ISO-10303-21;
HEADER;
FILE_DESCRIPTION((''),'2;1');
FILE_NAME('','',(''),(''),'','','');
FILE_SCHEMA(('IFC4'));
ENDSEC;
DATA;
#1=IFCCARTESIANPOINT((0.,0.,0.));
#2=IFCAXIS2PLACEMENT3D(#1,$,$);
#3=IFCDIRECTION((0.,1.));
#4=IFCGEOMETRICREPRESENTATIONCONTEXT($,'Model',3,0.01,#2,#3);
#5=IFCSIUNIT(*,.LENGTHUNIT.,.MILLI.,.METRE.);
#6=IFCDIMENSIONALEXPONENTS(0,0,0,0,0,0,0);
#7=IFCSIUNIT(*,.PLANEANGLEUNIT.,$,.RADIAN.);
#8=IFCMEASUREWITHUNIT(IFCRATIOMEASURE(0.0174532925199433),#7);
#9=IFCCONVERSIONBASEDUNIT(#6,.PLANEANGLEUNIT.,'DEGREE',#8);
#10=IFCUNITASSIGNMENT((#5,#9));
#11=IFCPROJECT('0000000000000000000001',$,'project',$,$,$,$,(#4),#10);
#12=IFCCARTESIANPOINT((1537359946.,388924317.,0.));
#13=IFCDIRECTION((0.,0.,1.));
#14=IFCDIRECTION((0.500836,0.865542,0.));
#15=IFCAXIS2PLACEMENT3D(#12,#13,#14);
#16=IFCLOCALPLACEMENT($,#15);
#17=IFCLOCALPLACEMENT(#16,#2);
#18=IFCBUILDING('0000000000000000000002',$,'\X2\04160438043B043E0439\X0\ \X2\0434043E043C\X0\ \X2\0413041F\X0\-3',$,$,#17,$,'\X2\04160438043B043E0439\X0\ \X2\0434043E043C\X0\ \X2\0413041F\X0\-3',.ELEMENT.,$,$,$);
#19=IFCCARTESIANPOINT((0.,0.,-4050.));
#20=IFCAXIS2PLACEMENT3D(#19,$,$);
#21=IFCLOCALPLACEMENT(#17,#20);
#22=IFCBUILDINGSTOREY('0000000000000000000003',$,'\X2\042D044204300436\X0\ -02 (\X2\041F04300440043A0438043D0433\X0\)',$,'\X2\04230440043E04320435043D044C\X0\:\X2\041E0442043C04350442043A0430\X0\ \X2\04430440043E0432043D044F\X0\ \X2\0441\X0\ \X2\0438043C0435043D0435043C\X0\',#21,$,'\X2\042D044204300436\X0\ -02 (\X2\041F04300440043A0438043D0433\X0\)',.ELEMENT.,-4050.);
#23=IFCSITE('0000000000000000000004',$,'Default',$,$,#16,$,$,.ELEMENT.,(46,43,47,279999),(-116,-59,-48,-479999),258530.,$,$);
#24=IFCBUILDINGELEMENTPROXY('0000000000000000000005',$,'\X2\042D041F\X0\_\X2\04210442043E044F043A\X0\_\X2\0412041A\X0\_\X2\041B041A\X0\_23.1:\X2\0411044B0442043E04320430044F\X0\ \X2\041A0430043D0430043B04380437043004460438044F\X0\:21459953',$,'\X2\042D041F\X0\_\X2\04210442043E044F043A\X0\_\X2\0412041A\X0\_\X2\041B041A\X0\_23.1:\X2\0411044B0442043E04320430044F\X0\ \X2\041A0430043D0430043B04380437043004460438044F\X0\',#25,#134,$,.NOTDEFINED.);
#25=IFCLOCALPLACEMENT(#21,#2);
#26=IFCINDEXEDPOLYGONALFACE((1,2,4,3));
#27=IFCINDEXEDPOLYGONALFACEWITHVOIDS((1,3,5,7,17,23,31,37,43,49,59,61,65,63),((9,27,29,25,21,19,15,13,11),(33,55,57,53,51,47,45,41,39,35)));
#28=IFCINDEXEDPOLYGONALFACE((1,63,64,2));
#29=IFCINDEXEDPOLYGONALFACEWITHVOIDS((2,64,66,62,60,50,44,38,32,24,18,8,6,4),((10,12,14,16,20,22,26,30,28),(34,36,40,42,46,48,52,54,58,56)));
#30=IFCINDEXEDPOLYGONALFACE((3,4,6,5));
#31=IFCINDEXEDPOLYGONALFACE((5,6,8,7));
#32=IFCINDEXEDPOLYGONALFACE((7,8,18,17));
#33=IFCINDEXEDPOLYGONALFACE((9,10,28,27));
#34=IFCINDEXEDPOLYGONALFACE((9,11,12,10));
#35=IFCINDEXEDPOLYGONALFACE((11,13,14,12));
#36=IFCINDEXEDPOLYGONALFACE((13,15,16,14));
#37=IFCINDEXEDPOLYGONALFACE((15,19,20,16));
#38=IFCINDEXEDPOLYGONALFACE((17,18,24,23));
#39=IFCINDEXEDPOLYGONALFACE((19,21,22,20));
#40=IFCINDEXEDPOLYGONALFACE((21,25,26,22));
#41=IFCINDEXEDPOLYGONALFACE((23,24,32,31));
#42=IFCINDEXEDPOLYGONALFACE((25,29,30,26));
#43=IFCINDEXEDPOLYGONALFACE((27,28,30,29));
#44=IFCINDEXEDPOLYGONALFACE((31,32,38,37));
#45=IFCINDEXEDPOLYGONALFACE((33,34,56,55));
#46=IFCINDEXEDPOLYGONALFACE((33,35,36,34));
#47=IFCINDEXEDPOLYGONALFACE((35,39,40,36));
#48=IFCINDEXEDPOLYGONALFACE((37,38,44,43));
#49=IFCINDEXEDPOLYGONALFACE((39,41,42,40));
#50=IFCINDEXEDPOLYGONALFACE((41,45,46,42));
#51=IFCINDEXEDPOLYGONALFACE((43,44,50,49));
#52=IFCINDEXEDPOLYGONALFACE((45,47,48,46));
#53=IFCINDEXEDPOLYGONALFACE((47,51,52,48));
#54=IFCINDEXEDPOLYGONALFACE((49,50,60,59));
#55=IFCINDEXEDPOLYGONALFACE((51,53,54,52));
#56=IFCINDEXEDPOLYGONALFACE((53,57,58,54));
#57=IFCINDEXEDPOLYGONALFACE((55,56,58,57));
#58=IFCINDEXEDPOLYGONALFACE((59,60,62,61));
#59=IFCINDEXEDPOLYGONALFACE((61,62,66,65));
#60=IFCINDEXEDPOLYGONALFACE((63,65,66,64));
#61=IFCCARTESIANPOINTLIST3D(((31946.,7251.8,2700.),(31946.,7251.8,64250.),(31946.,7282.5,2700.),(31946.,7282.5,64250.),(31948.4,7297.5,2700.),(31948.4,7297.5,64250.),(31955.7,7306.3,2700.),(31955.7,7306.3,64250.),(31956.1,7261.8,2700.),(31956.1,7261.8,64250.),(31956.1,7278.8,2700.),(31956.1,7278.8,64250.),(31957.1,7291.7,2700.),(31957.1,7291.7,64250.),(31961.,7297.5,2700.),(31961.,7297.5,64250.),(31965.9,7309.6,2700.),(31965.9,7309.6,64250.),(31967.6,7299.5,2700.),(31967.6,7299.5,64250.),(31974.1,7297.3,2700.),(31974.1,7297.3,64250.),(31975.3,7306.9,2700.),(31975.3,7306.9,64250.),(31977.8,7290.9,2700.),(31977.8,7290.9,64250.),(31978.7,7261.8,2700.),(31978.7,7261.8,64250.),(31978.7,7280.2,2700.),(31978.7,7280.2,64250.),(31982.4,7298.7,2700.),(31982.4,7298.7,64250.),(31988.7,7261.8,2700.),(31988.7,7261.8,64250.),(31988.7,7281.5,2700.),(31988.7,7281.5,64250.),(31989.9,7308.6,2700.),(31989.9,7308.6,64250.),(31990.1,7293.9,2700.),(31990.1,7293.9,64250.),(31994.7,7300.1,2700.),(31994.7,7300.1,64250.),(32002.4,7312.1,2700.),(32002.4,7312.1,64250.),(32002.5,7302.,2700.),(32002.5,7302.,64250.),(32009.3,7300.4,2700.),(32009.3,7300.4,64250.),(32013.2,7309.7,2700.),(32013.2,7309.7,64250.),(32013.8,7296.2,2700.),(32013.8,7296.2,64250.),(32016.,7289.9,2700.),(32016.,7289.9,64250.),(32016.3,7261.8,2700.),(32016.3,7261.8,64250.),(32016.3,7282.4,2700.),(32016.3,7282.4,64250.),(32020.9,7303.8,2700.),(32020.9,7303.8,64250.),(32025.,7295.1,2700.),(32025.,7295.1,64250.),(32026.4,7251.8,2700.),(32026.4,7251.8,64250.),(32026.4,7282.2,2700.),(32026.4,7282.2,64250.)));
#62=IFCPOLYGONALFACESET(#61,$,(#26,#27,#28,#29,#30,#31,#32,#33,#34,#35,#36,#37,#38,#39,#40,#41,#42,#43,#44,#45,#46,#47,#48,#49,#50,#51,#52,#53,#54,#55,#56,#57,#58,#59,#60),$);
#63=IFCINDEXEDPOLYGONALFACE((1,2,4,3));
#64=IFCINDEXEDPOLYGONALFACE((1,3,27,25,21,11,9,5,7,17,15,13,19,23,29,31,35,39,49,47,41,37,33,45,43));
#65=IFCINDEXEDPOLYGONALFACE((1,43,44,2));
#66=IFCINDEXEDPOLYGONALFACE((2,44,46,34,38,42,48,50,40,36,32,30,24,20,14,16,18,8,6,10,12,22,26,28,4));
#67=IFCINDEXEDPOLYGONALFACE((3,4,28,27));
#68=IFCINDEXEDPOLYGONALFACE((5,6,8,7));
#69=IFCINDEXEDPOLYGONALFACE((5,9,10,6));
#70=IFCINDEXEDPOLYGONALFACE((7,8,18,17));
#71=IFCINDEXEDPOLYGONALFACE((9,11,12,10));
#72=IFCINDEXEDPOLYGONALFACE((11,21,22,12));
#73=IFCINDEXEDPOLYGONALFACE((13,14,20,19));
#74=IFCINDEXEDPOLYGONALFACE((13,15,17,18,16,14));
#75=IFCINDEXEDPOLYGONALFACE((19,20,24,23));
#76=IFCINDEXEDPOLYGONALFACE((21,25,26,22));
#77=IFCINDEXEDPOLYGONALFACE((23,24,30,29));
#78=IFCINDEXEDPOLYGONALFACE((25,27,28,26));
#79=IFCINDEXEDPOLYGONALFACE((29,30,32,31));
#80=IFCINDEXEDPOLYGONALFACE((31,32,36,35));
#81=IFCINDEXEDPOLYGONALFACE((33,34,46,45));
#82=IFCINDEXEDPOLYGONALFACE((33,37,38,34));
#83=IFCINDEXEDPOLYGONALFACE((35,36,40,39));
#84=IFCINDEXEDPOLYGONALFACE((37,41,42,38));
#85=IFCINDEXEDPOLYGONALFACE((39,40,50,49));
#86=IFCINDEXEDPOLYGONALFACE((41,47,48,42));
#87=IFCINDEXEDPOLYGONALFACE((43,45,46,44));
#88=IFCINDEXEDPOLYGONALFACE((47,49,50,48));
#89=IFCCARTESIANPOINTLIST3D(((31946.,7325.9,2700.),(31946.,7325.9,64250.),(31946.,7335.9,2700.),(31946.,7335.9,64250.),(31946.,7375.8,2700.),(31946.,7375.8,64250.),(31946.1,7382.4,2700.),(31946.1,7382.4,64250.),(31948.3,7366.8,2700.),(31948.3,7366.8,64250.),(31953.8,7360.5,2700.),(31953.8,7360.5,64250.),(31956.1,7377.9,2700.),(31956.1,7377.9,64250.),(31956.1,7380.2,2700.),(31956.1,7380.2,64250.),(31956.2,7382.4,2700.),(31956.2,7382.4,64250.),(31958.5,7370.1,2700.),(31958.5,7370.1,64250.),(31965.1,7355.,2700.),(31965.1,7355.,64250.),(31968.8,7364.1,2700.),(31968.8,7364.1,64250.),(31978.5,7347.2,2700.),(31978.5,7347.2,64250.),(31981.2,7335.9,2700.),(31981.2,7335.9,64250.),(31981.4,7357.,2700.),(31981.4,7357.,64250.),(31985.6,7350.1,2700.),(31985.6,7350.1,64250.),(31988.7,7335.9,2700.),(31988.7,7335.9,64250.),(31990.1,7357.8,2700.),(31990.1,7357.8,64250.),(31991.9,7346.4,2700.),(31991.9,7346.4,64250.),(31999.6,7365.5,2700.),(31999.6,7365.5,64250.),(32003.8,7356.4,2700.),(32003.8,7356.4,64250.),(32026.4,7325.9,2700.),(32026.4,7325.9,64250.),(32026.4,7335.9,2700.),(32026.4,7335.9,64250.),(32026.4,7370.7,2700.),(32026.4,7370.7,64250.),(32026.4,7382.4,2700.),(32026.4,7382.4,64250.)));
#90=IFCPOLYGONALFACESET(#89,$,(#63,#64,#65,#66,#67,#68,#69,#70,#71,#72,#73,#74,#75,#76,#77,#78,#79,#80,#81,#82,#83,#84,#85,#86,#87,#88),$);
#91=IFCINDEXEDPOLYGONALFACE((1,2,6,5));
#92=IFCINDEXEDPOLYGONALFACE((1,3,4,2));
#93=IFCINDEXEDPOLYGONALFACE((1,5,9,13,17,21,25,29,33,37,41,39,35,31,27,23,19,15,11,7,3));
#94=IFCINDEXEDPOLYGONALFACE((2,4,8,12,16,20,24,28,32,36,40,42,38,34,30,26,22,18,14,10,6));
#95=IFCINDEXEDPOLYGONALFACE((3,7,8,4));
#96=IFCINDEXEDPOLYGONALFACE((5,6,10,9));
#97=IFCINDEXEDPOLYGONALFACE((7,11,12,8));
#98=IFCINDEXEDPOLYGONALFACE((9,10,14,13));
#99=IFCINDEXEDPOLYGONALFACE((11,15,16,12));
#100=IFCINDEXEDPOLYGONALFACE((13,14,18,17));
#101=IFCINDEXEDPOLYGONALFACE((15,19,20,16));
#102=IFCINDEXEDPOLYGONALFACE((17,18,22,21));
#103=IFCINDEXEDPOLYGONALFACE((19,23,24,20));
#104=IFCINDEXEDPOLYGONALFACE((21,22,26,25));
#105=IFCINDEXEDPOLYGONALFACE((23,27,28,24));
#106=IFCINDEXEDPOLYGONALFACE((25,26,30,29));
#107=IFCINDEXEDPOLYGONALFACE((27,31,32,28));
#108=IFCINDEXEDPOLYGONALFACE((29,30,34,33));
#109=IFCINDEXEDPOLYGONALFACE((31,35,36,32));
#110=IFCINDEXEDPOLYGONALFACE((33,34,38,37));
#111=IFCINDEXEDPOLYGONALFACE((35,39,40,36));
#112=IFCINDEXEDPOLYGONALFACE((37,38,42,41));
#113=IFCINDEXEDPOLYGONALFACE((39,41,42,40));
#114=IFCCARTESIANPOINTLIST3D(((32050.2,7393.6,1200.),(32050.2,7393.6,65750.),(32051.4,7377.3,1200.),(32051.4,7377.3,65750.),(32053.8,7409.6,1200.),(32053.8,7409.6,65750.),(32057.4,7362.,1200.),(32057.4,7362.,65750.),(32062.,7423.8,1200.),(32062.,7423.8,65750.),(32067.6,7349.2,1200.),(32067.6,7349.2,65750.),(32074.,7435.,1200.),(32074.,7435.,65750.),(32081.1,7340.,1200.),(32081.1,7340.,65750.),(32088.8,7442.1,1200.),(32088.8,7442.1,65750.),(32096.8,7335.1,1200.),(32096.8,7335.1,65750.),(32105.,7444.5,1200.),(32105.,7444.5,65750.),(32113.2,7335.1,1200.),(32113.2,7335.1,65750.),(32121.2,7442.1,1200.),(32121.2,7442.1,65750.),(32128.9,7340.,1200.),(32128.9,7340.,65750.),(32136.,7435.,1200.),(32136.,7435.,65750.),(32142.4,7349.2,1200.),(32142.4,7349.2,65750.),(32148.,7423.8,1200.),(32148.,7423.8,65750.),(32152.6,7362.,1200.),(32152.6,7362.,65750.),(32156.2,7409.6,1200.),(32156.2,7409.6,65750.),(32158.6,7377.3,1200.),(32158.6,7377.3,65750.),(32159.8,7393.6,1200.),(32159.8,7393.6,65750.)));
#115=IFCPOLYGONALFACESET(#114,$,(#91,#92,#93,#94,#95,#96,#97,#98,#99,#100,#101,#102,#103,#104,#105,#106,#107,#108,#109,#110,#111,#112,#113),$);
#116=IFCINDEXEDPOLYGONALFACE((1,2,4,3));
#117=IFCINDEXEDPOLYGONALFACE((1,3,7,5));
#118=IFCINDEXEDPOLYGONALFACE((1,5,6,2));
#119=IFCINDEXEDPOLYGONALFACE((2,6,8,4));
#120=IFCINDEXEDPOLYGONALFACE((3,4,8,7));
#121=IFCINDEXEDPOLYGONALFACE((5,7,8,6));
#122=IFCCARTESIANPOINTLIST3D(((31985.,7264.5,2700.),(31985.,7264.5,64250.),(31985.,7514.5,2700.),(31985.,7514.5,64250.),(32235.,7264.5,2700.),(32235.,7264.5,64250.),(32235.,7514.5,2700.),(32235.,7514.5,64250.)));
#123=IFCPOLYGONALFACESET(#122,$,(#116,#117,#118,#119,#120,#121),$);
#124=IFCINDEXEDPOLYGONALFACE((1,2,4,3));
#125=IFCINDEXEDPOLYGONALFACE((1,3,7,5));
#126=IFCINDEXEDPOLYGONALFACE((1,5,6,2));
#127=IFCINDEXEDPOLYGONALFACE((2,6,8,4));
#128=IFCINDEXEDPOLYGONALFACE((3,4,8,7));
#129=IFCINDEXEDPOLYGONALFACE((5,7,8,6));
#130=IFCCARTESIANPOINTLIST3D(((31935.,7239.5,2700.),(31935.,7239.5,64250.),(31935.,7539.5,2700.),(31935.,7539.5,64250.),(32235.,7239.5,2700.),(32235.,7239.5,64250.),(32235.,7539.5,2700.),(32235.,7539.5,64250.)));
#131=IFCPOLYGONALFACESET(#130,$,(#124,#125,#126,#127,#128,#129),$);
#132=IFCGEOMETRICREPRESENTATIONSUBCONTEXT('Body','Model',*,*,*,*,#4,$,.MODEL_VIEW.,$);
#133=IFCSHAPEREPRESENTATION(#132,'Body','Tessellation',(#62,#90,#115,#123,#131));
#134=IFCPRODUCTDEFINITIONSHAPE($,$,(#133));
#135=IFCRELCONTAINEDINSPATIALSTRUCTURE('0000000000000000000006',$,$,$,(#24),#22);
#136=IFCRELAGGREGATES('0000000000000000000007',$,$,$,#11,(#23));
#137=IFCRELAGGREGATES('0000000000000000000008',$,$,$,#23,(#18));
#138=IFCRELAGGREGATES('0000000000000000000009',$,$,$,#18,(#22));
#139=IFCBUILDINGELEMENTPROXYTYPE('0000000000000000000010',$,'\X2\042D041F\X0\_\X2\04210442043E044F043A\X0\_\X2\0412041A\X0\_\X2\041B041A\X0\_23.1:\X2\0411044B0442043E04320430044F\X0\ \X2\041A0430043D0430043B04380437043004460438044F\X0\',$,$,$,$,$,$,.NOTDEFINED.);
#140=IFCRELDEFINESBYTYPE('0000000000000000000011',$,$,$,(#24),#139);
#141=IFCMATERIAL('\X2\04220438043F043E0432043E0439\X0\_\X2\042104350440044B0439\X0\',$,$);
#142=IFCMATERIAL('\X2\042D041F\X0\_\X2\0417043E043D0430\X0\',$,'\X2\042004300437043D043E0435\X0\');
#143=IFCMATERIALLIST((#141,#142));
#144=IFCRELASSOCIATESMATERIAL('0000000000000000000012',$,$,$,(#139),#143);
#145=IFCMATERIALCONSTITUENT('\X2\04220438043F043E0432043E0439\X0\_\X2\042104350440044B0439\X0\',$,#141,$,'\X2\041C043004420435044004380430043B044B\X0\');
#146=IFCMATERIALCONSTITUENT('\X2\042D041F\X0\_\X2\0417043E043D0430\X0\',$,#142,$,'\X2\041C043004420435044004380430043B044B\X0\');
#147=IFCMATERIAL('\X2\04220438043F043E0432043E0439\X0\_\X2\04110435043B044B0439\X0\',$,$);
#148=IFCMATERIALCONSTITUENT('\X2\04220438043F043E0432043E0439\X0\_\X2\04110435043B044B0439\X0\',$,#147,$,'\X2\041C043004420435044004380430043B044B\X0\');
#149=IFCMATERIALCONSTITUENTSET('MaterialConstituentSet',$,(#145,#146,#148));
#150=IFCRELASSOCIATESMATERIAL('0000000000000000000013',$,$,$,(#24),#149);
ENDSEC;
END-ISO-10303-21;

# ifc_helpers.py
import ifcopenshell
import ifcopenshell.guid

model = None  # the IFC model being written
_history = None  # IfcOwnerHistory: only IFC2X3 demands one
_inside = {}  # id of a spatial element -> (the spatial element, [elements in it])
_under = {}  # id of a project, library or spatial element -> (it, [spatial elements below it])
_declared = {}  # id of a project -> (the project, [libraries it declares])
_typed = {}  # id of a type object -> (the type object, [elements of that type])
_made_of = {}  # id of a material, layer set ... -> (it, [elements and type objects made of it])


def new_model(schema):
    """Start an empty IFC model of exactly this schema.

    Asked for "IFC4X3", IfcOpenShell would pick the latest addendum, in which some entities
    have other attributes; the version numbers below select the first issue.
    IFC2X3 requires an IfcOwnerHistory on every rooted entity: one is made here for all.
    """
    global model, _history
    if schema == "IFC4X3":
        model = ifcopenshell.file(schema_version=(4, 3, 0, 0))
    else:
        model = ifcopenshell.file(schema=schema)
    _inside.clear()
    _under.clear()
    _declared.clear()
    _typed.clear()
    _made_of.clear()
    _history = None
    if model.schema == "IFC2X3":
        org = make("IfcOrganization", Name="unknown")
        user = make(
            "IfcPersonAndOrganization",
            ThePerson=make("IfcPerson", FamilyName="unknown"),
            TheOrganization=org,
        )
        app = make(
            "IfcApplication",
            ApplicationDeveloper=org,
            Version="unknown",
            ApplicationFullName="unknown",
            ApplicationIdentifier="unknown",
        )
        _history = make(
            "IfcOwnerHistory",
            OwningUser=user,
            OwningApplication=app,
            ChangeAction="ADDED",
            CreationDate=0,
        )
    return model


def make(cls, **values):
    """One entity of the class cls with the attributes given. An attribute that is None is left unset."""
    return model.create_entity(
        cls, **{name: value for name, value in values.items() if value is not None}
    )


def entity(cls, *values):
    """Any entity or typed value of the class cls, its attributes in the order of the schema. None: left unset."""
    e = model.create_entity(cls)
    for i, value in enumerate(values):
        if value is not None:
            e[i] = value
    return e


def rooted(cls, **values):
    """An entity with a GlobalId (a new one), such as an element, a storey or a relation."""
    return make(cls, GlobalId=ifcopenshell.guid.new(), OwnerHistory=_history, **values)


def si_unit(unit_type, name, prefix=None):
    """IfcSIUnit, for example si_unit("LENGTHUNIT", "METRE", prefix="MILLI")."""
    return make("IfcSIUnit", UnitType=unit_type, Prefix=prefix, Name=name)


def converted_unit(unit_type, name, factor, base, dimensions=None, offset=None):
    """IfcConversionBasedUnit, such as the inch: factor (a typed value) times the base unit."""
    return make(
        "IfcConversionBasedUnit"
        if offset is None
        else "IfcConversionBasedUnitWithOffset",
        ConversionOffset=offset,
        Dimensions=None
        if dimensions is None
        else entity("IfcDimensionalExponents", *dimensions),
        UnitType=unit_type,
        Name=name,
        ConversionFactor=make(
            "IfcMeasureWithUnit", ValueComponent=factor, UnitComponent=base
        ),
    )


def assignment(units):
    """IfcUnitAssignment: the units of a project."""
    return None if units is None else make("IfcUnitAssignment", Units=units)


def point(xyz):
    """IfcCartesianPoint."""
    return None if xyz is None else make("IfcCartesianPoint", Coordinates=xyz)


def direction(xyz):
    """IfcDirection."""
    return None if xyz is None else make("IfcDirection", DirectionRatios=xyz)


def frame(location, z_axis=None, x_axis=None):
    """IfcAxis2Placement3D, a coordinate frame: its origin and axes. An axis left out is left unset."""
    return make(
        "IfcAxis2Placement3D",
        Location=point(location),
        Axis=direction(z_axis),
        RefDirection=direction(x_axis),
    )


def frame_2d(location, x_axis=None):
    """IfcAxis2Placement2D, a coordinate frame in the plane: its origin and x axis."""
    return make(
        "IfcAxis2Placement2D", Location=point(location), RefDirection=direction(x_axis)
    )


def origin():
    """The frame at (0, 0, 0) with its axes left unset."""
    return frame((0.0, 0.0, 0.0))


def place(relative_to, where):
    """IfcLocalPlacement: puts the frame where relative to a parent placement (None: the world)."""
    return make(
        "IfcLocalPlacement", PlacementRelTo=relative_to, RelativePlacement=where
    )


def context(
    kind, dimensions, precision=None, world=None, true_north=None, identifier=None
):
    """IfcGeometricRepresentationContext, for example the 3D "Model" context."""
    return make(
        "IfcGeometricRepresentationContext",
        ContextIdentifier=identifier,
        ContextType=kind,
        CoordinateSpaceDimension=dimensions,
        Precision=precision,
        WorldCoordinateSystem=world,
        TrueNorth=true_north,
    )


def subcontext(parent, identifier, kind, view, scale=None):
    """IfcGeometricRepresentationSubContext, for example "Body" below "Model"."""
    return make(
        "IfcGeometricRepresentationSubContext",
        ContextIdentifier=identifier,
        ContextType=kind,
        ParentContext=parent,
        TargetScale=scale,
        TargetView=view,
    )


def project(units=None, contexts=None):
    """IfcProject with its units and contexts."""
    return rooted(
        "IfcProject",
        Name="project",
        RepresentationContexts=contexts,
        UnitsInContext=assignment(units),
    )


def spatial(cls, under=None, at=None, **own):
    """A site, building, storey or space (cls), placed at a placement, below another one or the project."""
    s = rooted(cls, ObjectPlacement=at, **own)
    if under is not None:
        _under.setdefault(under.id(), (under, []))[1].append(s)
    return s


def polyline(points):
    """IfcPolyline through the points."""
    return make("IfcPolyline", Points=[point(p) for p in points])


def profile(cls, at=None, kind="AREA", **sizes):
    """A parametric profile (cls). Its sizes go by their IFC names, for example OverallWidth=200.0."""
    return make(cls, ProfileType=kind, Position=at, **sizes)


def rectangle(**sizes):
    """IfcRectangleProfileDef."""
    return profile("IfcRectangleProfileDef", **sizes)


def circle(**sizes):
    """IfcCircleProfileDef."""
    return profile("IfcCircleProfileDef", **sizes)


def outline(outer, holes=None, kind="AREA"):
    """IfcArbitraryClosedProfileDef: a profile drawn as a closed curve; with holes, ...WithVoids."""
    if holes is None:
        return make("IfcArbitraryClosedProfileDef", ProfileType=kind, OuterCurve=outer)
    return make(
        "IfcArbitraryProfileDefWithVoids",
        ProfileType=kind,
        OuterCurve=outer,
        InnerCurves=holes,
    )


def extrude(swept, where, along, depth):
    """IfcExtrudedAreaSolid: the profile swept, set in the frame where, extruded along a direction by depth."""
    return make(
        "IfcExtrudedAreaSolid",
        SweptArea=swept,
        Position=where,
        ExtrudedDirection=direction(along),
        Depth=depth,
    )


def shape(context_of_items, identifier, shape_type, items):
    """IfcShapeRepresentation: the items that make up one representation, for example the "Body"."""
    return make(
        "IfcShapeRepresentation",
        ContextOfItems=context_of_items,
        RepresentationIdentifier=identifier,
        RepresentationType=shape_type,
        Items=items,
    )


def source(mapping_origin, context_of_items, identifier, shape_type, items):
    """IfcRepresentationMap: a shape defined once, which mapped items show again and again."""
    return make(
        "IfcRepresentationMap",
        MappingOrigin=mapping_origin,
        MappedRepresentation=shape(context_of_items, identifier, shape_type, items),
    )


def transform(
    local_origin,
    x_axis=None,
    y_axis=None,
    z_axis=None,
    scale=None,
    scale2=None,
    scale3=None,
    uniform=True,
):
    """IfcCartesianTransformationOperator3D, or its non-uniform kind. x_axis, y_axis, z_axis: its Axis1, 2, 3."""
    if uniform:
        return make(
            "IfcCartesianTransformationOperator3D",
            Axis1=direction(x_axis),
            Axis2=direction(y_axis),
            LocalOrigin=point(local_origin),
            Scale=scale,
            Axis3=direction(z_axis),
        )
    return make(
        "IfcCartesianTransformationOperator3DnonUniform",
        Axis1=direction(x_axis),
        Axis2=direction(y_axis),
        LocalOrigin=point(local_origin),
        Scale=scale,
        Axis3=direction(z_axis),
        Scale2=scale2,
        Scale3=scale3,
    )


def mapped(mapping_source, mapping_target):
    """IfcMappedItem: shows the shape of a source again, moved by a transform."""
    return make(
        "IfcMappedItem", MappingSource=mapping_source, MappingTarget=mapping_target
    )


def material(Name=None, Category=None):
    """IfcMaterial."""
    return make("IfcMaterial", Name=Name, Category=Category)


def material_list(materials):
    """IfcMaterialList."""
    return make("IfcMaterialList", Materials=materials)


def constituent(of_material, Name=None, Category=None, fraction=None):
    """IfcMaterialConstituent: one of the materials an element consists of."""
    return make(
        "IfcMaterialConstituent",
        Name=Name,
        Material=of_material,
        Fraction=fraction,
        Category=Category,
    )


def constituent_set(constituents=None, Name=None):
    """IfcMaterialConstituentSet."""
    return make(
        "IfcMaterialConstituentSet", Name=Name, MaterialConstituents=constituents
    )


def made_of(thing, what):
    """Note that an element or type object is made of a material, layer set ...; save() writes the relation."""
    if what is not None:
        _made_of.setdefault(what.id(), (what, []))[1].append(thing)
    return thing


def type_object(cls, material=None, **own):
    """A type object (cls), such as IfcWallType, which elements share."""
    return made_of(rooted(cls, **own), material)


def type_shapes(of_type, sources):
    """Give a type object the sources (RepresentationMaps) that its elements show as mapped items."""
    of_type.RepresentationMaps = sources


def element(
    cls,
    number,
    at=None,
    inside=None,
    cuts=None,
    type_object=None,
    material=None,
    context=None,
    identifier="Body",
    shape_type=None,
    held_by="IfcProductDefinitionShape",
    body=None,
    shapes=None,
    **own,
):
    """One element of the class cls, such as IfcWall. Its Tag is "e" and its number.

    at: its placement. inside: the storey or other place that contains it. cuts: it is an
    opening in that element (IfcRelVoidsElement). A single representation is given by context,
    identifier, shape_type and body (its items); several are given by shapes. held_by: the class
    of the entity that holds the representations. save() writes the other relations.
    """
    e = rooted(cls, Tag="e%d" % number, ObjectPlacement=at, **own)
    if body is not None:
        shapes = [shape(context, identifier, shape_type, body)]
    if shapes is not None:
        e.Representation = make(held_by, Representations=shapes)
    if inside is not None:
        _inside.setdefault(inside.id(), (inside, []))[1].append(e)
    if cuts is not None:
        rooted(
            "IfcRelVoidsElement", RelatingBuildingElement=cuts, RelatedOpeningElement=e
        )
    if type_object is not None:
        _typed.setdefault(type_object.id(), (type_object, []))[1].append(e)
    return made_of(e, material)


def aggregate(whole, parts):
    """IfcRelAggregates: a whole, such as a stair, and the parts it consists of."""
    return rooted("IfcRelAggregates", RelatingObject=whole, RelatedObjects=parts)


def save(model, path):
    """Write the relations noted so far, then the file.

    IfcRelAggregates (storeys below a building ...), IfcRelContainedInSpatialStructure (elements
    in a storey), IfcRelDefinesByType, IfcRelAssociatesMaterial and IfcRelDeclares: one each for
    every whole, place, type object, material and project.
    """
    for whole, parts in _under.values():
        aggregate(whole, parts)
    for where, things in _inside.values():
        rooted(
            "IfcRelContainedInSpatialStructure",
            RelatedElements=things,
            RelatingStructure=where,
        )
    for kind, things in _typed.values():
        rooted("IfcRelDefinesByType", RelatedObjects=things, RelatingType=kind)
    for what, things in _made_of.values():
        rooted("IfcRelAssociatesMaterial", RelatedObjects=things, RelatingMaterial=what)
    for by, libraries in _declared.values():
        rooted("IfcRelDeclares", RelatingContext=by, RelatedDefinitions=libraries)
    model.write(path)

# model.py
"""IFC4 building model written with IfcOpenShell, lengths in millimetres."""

from ifc_helpers import new_model, entity, si_unit, converted_unit, direction, frame, frame_2d, origin, place, context, subcontext, project, spatial, polyline, rectangle, circle, outline, extrude, source, transform, mapped, material, material_list, constituent, constituent_set, type_object, type_shapes, element, save


model = new_model("IFC4")

# Units and contexts
model_context = context("Model", 3, precision=0.01, world=origin(), true_north=direction((0.0, 1.0)))
body_context = subcontext(model_context, "Body", "Model", "MODEL_VIEW")
ifc_project = project(units=[si_unit("LENGTHUNIT", "METRE", prefix="MILLI"), converted_unit("PLANEANGLEUNIT", "DEGREE", entity("IfcRatioMeasure", 0.0174532925199433), si_unit("PLANEANGLEUNIT", "RADIAN"), dimensions=[0, 0, 0, 0, 0, 0, 0])], contexts=[model_context])

# Site, building, storey
site_placement = place(None, frame((1537359946.0, 388924317.0, 0.0), z_axis=(0.0, 0.0, 1.0), x_axis=(0.500836, 0.865542, 0.0)))
site = spatial("IfcSite", under=ifc_project, at=site_placement, Name="Default", CompositionType="ELEMENT", RefLatitude=(46, 43, 47, 279999), RefLongitude=(-116, -59, -48, -479999), RefElevation=258530.0)
building_placement = place(site_placement, origin())
building = spatial("IfcBuilding", under=site, at=building_placement, Name="Жилой дом ГП-3", LongName="Жилой дом ГП-3", CompositionType="ELEMENT")
storey_placement = place(building_placement, frame((0.0, 0.0, -4050.0)))
storey = spatial("IfcBuildingStorey", under=building, at=storey_placement, Name="Этаж -02 (Паркинг)", ObjectType="Уровень:Отметка уровня с именем", LongName="Этаж -02 (Паркинг)", CompositionType="ELEMENT", Elevation=-4050.0)

# Building element proxy
ifc_material_1 = material(Name="ЭП_Зона", Category="Разное")
ifc_material_2 = material(Name="Типовой_Белый")
ifc_material_3 = material(Name="Типовой_Серый")
ifc_constituent_1 = constituent(ifc_material_3, Name="Типовой_Серый", Category="Материалы")
ifc_constituent_2 = constituent(ifc_material_1, Name="ЭП_Зона", Category="Материалы")
ifc_constituent_3 = constituent(ifc_material_2, Name="Типовой_Белый", Category="Материалы")
ifc_constituent_set_1 = constituent_set(constituents=[ifc_constituent_1, ifc_constituent_2, ifc_constituent_3], Name="MaterialConstituentSet")
ifc_material_list_1 = material_list([ifc_material_3, ifc_material_1])
building_element_proxy_type_1 = type_object("IfcBuildingElementProxyType", Name="ЭП_Стояк_ВК_ЛК_23.1:Бытовая Канализация", PredefinedType="NOTDEFINED", material=ifc_material_list_1)
shared_shape_1 = source(origin(), body_context, "Body", "SweptSolid", [
    extrude(outline(polyline([(-42.2, -39.0), (-11.8, -39.0), (1.1, -37.6), (9.8, -33.5), (15.7, -25.8), (18.0, -15.0), (14.6, -2.5), (4.7, 5.0), (12.8, 12.1), (15.5, 21.5), (12.3, 31.8), (3.4, 39.0), (-11.6, 41.4), (-42.2, 41.4), (-42.2, -39.0)]), holes=[polyline([(-32.2, 8.8), (-32.2, 31.4), (-15.2, 31.4), (-2.3, 30.3), (3.5, 26.4), (5.5, 19.9), (3.3, 13.3), (-3.1, 9.6), (-13.9, 8.8), (-32.2, 8.8)]), polyline([(-32.2, -28.9), (-32.2, -1.3), (-12.6, -1.3), (-0.2, -2.6), (6.1, -7.3), (8.0, -15.1), (6.3, -21.9), (2.2, -26.3), (-4.1, -28.5), (-11.6, -28.9), (-32.2, -28.9)])]), frame((54.5, -52.4, -1350.0)), (0.0, 0.0, 1.0), 61550.0),
    extrude(outline(polyline([(-32.1, -31.9), (48.3, -31.9), (48.3, -21.8), (10.6, -21.8), (13.8, -11.4), (25.6, -1.3), (48.3, 13.0), (48.3, 24.6), (21.4, 7.7), (12.0, 0.1), (7.4, -7.7), (3.3, -0.7), (-9.3, 6.4), (-19.7, 12.3), (-22.1, 20.2), (-22.0, 22.4), (-22.0, 24.6), (-32.0, 24.6), (-32.1, 18.0), (-29.9, 9.0), (-24.3, 2.8), (-13.1, -2.8), (0.4, -10.6), (3.0, -21.8), (-32.1, -21.8), (-32.1, -31.9)])), frame((118.2, -43.1, -1350.0), z_axis=(0.0, 0.0, 1.0), x_axis=(0.0, -1.0, 0.0)), (0.0, 0.0, 1.0), 61550.0),
    extrude(circle(Radius=55.0, at=frame_2d((0.0, 0.0), x_axis=(1.0, 0.0))), frame((150.0, -170.0, -2850.0)), (0.0, 0.0, 1.0), 64550.0),
    extrude(rectangle(XDim=250.0, YDim=250.0, at=frame_2d((0.0, 0.0), x_axis=(1.0, 0.0))), frame((150.0, -175.0, -1350.0)), (0.0, 0.0, 1.0), 61550.0),
    extrude(rectangle(XDim=300.0, YDim=300.0, at=frame_2d((0.0, 0.0), x_axis=(1.0, 0.0))), frame((150.0, -150.0, -1350.0)), (0.0, 0.0, 1.0), 61550.0),
])
type_shapes(building_element_proxy_type_1, [shared_shape_1])
proxy_1_placement = place(storey_placement, frame((31935.0, 7239.5, 4050.0), z_axis=(0.0, 0.0, 1.0), x_axis=(0.0, 1.0, 0.0)))
element("IfcBuildingElementProxy", 1, at=proxy_1_placement, inside=storey, type_object=building_element_proxy_type_1, material=ifc_constituent_set_1, Name="ЭП_Стояк_ВК_ЛК_23.1:Бытовая Канализация:21459953", ObjectType="ЭП_Стояк_ВК_ЛК_23.1:Бытовая Канализация", PredefinedType="NOTDEFINED", context=body_context, shape_type="MappedRepresentation", body=[
    mapped(shared_shape_1, transform((0.0, 0.0, 0.0), scale=1.0)),
])

save(model, "model.ifc")
